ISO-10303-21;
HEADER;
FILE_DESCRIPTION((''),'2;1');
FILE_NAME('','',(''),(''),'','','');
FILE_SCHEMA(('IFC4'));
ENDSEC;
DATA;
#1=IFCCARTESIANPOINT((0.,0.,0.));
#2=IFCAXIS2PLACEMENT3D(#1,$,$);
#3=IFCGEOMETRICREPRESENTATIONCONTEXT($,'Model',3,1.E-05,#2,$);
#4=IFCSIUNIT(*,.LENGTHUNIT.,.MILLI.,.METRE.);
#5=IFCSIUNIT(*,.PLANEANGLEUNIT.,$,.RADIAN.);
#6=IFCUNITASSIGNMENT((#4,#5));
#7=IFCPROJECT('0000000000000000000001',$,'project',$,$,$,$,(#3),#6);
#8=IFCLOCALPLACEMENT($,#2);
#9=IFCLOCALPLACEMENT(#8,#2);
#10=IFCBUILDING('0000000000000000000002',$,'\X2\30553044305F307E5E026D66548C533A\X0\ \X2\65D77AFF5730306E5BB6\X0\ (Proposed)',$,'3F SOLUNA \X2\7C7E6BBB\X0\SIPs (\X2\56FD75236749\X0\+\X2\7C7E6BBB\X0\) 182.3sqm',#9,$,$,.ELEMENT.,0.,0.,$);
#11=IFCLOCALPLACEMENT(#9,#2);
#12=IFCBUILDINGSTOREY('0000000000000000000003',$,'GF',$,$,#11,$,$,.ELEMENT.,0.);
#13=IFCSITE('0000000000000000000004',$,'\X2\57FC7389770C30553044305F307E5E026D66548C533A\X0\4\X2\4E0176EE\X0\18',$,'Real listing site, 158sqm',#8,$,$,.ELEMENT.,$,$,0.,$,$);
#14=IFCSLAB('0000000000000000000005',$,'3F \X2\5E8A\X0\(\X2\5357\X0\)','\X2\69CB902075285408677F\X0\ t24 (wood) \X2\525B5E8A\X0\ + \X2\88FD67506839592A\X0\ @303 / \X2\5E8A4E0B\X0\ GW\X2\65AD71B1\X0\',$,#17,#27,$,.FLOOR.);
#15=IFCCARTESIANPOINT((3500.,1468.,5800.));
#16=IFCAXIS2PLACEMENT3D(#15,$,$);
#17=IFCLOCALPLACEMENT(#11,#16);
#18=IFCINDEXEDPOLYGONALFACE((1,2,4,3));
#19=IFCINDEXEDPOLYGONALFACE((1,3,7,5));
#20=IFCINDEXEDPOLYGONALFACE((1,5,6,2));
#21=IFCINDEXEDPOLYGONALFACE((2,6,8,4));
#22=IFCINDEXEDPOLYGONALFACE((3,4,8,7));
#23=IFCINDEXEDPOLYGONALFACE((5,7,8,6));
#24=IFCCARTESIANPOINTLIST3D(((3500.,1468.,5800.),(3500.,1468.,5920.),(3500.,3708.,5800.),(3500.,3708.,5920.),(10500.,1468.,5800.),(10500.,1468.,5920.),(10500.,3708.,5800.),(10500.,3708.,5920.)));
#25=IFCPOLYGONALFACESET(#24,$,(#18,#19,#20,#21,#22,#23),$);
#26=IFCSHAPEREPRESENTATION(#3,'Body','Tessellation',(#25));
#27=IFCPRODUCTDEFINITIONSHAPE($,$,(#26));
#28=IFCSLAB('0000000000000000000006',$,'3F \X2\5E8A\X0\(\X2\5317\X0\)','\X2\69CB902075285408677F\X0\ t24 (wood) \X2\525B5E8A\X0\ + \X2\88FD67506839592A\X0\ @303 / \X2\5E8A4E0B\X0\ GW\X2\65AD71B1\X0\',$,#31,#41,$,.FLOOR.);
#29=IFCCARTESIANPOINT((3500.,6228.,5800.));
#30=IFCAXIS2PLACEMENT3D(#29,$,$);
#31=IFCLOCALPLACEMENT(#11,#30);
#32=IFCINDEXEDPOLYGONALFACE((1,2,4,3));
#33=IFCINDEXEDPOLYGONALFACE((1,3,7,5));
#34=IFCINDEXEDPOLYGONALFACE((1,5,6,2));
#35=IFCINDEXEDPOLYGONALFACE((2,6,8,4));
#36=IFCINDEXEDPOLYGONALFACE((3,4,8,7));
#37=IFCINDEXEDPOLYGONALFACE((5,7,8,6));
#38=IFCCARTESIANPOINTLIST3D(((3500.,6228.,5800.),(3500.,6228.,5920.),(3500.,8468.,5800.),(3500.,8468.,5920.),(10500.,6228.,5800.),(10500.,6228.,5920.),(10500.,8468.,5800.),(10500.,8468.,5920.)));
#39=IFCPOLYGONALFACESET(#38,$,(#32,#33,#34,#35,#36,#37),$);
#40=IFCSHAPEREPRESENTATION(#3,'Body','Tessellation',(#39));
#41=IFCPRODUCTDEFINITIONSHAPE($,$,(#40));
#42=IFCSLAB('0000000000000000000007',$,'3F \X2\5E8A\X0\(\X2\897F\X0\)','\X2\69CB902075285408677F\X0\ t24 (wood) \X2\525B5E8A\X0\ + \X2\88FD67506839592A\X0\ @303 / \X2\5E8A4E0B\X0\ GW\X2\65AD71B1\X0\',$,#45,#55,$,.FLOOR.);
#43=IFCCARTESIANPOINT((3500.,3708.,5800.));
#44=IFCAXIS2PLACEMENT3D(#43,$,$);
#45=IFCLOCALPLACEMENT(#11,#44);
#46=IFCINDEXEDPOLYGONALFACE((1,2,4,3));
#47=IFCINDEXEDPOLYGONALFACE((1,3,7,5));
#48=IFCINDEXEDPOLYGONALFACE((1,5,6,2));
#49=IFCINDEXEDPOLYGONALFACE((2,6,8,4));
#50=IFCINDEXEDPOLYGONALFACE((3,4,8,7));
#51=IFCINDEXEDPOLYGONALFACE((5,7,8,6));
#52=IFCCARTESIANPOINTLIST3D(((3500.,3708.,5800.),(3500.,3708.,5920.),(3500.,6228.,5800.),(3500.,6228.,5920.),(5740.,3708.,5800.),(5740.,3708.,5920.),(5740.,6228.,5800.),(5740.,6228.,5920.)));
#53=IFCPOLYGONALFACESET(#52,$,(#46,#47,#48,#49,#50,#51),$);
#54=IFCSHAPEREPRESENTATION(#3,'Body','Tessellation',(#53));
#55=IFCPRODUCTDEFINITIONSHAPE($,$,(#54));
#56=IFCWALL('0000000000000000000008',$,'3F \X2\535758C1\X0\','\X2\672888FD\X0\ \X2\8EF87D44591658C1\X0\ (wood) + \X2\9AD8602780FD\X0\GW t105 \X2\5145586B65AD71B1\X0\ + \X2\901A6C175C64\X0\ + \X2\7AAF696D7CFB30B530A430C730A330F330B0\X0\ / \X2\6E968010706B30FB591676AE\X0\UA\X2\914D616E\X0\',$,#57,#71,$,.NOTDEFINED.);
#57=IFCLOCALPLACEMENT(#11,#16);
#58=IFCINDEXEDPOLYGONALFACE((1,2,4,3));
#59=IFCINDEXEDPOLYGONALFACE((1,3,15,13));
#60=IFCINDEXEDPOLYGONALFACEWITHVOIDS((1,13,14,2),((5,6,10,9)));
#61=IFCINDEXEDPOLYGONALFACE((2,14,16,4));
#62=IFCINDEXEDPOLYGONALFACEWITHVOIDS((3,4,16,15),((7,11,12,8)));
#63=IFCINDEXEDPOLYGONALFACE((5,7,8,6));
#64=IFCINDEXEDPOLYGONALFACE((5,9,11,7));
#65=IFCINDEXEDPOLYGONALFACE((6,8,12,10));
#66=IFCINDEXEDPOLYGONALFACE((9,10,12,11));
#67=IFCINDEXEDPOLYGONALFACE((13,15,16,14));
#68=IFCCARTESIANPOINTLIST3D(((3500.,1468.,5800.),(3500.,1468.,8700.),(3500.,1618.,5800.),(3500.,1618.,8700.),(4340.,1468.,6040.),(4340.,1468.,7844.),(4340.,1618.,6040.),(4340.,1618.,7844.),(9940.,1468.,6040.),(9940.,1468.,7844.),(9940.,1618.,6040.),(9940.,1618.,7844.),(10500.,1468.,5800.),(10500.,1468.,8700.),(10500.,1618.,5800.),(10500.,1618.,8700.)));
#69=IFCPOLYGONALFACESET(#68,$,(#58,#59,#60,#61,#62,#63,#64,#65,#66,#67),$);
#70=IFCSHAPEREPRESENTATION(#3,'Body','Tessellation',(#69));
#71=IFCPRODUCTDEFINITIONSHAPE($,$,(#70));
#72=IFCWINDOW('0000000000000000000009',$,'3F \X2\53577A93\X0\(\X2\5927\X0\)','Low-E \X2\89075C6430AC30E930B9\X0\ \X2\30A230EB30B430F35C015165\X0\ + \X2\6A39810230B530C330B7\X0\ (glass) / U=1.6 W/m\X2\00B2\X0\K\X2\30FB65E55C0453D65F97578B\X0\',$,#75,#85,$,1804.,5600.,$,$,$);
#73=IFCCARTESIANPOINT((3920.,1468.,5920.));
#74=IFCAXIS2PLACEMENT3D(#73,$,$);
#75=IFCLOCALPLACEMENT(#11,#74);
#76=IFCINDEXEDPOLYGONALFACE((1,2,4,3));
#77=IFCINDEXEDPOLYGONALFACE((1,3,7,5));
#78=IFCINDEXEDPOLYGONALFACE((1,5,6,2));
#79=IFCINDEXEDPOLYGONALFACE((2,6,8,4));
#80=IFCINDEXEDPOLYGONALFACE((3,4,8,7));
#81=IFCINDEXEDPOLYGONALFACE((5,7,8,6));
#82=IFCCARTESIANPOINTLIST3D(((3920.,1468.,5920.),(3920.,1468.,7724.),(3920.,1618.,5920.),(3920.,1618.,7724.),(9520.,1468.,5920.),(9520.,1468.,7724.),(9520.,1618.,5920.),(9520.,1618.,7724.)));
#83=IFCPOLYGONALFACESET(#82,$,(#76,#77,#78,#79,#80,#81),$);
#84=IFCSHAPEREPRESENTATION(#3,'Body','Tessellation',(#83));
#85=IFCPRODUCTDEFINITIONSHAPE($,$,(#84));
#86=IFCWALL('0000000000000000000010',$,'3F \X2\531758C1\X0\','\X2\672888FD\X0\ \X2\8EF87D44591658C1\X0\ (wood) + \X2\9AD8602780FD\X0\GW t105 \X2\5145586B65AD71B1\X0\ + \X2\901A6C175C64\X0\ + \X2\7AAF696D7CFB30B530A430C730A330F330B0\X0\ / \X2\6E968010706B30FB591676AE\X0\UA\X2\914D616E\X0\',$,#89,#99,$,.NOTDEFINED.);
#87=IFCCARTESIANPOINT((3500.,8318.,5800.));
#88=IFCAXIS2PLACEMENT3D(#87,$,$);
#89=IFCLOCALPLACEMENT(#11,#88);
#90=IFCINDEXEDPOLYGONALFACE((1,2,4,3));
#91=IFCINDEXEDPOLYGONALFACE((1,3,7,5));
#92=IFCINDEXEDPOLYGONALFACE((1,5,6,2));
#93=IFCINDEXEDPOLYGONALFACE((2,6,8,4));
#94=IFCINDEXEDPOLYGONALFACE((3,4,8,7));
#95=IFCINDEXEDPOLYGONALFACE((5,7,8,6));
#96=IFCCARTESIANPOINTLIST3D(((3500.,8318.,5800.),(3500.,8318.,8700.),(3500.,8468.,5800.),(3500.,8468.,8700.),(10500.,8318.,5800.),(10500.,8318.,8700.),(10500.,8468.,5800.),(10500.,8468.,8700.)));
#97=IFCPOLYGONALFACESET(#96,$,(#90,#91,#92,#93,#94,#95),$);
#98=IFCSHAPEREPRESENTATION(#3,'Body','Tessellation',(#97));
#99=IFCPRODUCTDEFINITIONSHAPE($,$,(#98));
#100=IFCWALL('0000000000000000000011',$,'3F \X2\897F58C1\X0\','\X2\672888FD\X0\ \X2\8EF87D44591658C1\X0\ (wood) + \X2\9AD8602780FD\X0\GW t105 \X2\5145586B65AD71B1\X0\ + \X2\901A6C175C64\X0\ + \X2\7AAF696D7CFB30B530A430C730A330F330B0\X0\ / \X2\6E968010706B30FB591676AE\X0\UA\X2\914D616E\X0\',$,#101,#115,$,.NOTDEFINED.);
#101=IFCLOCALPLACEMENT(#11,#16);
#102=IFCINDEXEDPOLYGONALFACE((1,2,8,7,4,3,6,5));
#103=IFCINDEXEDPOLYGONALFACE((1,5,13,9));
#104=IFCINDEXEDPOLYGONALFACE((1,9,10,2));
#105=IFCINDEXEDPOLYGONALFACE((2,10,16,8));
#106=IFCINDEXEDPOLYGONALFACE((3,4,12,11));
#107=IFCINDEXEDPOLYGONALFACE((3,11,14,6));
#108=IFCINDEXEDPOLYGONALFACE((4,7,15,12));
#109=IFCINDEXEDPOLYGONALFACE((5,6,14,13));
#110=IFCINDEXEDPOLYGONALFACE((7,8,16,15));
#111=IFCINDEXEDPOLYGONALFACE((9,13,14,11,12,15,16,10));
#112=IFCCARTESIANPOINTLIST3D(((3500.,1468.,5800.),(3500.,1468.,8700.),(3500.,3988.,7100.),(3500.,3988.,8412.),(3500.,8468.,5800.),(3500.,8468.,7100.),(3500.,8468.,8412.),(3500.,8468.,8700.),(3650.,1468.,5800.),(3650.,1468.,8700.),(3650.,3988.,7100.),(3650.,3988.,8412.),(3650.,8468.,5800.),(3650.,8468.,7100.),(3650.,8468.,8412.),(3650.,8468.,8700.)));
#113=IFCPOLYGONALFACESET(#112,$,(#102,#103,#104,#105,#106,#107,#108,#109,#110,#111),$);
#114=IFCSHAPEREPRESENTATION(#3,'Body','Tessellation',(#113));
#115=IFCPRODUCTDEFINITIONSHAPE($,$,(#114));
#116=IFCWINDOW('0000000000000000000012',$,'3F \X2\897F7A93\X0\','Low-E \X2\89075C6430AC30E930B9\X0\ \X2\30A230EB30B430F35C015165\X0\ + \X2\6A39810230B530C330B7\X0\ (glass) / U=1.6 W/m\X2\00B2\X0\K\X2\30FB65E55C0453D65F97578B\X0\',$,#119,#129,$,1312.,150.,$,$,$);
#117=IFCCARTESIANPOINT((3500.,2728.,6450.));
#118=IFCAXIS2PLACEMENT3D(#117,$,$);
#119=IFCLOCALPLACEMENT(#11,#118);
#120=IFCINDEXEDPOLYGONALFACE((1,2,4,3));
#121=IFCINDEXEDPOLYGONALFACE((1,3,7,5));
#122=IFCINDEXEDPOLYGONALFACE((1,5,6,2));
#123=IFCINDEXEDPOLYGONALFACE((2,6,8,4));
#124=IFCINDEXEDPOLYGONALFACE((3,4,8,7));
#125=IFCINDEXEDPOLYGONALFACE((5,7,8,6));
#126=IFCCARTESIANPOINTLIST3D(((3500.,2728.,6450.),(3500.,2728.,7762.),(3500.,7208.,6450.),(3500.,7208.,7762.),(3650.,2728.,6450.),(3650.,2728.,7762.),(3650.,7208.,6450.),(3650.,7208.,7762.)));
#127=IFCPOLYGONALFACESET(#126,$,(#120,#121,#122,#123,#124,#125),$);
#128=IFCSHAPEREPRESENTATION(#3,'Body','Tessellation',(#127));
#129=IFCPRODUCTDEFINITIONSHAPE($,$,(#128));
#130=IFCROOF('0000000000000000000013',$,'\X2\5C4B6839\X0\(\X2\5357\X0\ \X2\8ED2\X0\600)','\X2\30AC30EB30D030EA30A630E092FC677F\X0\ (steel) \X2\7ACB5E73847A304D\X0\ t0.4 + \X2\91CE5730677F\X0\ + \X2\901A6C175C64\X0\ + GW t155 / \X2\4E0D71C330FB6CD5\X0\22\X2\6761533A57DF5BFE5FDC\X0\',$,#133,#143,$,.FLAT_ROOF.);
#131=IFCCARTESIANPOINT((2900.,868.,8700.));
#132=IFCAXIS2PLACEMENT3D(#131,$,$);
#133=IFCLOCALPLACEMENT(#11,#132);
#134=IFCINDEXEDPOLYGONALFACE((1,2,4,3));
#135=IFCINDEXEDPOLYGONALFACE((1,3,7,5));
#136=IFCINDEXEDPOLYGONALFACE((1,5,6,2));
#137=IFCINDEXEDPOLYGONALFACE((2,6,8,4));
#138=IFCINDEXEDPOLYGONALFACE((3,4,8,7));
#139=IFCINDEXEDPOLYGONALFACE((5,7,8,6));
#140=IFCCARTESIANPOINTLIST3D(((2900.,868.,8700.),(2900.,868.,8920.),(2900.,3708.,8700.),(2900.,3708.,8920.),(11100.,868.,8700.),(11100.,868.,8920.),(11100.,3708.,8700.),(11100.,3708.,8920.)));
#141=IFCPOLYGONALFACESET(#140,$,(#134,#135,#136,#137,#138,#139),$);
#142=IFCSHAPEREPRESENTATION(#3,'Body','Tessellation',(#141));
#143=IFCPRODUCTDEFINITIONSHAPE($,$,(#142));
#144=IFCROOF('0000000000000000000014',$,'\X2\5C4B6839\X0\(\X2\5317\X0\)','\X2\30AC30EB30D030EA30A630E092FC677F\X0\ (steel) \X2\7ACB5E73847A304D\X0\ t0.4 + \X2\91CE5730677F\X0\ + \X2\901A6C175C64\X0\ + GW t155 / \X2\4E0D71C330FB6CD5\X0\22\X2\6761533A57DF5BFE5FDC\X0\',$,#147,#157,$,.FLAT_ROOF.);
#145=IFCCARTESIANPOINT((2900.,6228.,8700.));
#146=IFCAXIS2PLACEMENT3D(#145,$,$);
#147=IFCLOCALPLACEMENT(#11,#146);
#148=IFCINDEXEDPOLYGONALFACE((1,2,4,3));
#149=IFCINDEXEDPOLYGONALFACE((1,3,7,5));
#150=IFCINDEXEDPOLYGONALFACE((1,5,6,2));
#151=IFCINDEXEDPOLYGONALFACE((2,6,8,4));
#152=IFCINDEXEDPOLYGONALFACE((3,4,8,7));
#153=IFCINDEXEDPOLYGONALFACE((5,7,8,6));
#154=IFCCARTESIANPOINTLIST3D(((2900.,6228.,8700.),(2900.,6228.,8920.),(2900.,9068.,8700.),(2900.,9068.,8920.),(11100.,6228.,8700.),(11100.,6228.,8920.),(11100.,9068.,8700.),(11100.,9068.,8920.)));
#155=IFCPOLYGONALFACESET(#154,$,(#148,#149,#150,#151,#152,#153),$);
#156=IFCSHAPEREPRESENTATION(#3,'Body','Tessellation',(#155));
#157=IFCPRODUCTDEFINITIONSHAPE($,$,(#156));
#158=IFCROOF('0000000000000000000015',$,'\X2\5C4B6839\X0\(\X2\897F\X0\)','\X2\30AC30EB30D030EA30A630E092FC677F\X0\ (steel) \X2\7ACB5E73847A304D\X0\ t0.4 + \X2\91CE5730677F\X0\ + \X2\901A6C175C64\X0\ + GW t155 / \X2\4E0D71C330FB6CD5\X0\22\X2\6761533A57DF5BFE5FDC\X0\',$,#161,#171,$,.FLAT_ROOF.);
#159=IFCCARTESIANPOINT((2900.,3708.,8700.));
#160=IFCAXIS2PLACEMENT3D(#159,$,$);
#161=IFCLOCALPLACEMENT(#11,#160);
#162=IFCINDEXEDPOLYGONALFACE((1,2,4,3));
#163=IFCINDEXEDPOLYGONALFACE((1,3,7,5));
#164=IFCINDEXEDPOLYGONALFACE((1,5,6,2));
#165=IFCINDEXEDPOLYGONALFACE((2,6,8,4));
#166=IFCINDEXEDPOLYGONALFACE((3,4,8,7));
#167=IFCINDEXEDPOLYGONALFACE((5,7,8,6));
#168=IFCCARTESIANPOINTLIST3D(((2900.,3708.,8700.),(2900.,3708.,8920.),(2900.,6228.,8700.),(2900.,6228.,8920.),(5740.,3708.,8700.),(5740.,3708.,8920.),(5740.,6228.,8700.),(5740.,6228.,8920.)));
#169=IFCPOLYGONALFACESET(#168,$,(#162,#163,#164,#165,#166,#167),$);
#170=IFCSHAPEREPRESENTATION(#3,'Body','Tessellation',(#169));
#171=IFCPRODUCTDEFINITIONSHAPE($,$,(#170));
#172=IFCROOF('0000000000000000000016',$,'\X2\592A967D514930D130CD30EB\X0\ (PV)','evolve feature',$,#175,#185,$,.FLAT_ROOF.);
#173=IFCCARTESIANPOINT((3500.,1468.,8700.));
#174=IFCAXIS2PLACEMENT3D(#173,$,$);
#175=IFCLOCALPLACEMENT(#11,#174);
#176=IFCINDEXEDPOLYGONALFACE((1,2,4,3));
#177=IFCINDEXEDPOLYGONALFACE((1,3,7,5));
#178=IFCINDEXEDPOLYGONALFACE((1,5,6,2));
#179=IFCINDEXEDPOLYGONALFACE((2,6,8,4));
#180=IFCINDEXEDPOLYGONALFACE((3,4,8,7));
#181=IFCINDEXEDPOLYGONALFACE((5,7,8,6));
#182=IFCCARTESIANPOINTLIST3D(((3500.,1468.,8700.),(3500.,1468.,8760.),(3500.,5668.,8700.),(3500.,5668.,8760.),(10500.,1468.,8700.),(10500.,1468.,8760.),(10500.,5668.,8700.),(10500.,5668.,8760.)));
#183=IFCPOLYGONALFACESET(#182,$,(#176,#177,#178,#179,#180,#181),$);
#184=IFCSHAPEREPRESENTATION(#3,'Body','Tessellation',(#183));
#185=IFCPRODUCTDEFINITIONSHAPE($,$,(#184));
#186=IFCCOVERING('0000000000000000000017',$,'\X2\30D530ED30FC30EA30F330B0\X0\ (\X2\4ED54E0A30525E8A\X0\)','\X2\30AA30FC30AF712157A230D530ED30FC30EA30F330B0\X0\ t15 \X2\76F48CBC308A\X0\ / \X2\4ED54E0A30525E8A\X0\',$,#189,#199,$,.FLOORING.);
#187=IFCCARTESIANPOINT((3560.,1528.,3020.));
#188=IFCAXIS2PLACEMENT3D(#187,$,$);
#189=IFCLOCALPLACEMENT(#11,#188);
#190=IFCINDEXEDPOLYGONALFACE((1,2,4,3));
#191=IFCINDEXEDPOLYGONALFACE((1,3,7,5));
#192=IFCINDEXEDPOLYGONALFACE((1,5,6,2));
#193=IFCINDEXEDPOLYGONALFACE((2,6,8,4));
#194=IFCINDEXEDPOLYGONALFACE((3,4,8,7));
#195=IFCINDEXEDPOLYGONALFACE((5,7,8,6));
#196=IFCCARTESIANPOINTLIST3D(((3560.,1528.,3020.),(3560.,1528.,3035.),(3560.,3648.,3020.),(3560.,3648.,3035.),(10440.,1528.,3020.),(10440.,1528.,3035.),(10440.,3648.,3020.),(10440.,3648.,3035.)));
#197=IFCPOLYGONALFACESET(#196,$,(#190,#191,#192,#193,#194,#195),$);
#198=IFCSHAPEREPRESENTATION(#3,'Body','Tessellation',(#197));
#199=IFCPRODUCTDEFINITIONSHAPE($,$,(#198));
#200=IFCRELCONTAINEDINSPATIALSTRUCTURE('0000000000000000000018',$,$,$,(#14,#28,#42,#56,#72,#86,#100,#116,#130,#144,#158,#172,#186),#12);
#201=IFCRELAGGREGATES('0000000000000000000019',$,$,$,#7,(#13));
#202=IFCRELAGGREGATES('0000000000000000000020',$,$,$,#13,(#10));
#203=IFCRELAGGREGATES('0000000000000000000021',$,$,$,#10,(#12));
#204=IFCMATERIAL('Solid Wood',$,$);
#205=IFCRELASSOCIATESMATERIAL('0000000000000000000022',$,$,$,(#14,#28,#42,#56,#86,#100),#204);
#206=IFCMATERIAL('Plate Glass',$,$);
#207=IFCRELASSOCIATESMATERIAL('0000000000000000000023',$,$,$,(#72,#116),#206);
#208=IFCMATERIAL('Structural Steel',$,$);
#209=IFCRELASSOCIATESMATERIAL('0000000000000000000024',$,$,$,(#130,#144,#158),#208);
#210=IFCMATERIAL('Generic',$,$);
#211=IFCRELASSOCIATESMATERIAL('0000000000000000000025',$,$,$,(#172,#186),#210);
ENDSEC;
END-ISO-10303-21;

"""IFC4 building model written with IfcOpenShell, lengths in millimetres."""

from ifc_helpers import new_model, si_unit, frame, frame_2d, origin, place, context, project, spatial, rectangle, extrude, material, element, fill, save


model = new_model("IFC4")

# Units and contexts
model_context = context("Model", 3, precision=1e-05, world=origin())
ifc_project = project(units=[si_unit("LENGTHUNIT", "METRE", prefix="MILLI"), si_unit("PLANEANGLEUNIT", "RADIAN")], contexts=[model_context])

# Site, building, storey
site_placement = place(None, origin())
site = spatial("IfcSite", under=ifc_project, at=site_placement, Name="埼玉県さいたま市浦和区4丁目18", ObjectType="Real listing site, 158sqm", CompositionType="ELEMENT", RefElevation=0.0)
building_placement = place(site_placement, origin())
building = spatial("IfcBuilding", under=site, at=building_placement, Name="さいたま市浦和区 旗竿地の家 (Proposed)", ObjectType="3F SOLUNA 籾殻SIPs (国産杉+籾殻) 182.3sqm", CompositionType="ELEMENT", ElevationOfRefHeight=0.0, ElevationOfTerrain=0.0)
storey_placement = place(building_placement, origin())
storey = spatial("IfcBuildingStorey", under=building, at=storey_placement, Name="GF", CompositionType="ELEMENT", Elevation=0.0)

# Slabs
ifc_material_1 = material(Name="Solid Wood")
slab_1_placement = place(storey_placement, frame((3500.0, 1468.0, 5800.0)))
element("IfcSlab", 1, at=slab_1_placement, inside=storey, material=ifc_material_1, Name="3F 床(南)", Description="構造用合板 t24 (wood) 剛床 + 製材根太 @303 / 床下 GW断熱", PredefinedType="FLOOR", context=model_context, shape_type="SweptSolid", body=[
    extrude(rectangle(XDim=7000.0, YDim=2240.0, at=frame_2d((3500.0, 1120.0))), frame((3500.0, 1468.0, 5800.0)), (0.0, 0.0, 1.0), 120.0),
])
slab_2_placement = place(storey_placement, frame((3500.0, 6228.0, 5800.0)))
element("IfcSlab", 2, at=slab_2_placement, inside=storey, material=ifc_material_1, Name="3F 床(北)", Description="構造用合板 t24 (wood) 剛床 + 製材根太 @303 / 床下 GW断熱", PredefinedType="FLOOR", context=model_context, shape_type="SweptSolid", body=[
    extrude(rectangle(XDim=7000.0, YDim=2240.0, at=frame_2d((3500.0, 1120.0))), frame((3500.0, 6228.0, 5800.0)), (0.0, 0.0, 1.0), 120.0),
])
slab_3_placement = place(storey_placement, frame((3500.0, 3708.0, 5800.0)))
element("IfcSlab", 3, at=slab_3_placement, inside=storey, material=ifc_material_1, Name="3F 床(西)", Description="構造用合板 t24 (wood) 剛床 + 製材根太 @303 / 床下 GW断熱", PredefinedType="FLOOR", context=model_context, shape_type="SweptSolid", body=[
    extrude(rectangle(XDim=2240.0, YDim=2520.0, at=frame_2d((1120.0, 1260.0))), frame((3500.0, 3708.0, 5800.0)), (0.0, 0.0, 1.0), 120.0),
])

# Wall, opening, window
wall_1_placement = place(storey_placement, frame((3500.0, 1468.0, 5800.0)))
wall_1 = element("IfcWall", 4, at=wall_1_placement, inside=storey, material=ifc_material_1, Name="3F 南壁", Description="木製 軸組外壁 (wood) + 高性能GW t105 充填断熱 + 通気層 + 窯業系サイディング / 準耐火・外皮UA配慮", PredefinedType="NOTDEFINED", context=model_context, shape_type="SweptSolid", body=[
    extrude(rectangle(XDim=7000.0, YDim=150.0, at=frame_2d((3500.0, 75.0))), frame((3500.0, 1468.0, 5800.0)), (0.0, 0.0, 1.0), 2900.0),
])
opening_1_placement = place(storey_placement, frame((3920.0, 1468.0, 5920.0)))
opening_1 = element("IfcOpeningElement", 5, at=opening_1_placement, cuts=wall_1, PredefinedType="NOTDEFINED", context=model_context, shape_type="SweptSolid", body=[
    extrude(rectangle(XDim=5600.0, YDim=150.0, at=frame_2d((2800.0, 75.0))), frame((3920.0, 1468.0, 5920.0)), (0.0, 0.0, 1.0), 1804.0),
])
ifc_material_2 = material(Name="Plate Glass")
window_1_placement = place(storey_placement, frame((3920.0, 1468.0, 5920.0)))
window_1 = element("IfcWindow", 6, at=window_1_placement, inside=storey, material=ifc_material_2, Name="3F 南窓(大)", Description="Low-E 複層ガラス アルゴン封入 + 樹脂サッシ (glass) / U=1.6 W/m²K・日射取得型", OverallHeight=1804.0, OverallWidth=5600.0, context=model_context, shape_type="SweptSolid", body=[
    extrude(rectangle(XDim=5600.0, YDim=150.0, at=frame_2d((2800.0, 75.0))), frame((3920.0, 1468.0, 5920.0)), (0.0, 0.0, 1.0), 1804.0),
])
fill(opening_1, window_1)

# Wall
wall_2_placement = place(storey_placement, frame((3500.0, 8318.0, 5800.0)))
element("IfcWall", 7, at=wall_2_placement, inside=storey, material=ifc_material_1, Name="3F 北壁", Description="木製 軸組外壁 (wood) + 高性能GW t105 充填断熱 + 通気層 + 窯業系サイディング / 準耐火・外皮UA配慮", PredefinedType="NOTDEFINED", context=model_context, shape_type="SweptSolid", body=[
    extrude(rectangle(XDim=7000.0, YDim=150.0, at=frame_2d((3500.0, 75.0))), frame((3500.0, 8318.0, 5800.0)), (0.0, 0.0, 1.0), 2900.0),
])

# Wall, opening, window
wall_3_placement = place(storey_placement, frame((3500.0, 1468.0, 5800.0)))
wall_3 = element("IfcWall", 8, at=wall_3_placement, inside=storey, material=ifc_material_1, Name="3F 西壁", Description="木製 軸組外壁 (wood) + 高性能GW t105 充填断熱 + 通気層 + 窯業系サイディング / 準耐火・外皮UA配慮", PredefinedType="NOTDEFINED", context=model_context, shape_type="SweptSolid", body=[
    extrude(rectangle(XDim=150.0, YDim=7000.0, at=frame_2d((75.0, 3500.0))), frame((3500.0, 1468.0, 5800.0)), (0.0, 0.0, 1.0), 2900.0),
])
opening_2_placement = place(storey_placement, frame((3500.0, 2728.0, 6450.0)))
opening_2 = element("IfcOpeningElement", 9, at=opening_2_placement, cuts=wall_3, PredefinedType="NOTDEFINED", context=model_context, shape_type="SweptSolid", body=[
    extrude(rectangle(XDim=150.0, YDim=4480.0, at=frame_2d((75.0, 2240.0))), frame((3500.0, 2728.0, 6450.0)), (0.0, 0.0, 1.0), 1312.0),
])
window_2_placement = place(storey_placement, frame((3500.0, 2728.0, 6450.0)))
window_2 = element("IfcWindow", 10, at=window_2_placement, inside=storey, material=ifc_material_2, Name="3F 西窓", Description="Low-E 複層ガラス アルゴン封入 + 樹脂サッシ (glass) / U=1.6 W/m²K・日射取得型", OverallHeight=1312.0, OverallWidth=150.0, context=model_context, shape_type="SweptSolid", body=[
    extrude(rectangle(XDim=150.0, YDim=4480.0, at=frame_2d((75.0, 2240.0))), frame((3500.0, 2728.0, 6450.0)), (0.0, 0.0, 1.0), 1312.0),
])
fill(opening_2, window_2)

# Roofs
ifc_material_3 = material(Name="Structural Steel")
roof_1_placement = place(storey_placement, frame((2900.0, 868.0, 8700.0)))
element("IfcRoof", 11, at=roof_1_placement, inside=storey, material=ifc_material_3, Name="屋根(南 軒600)", Description="ガルバリウム鋼板 (steel) 立平葺き t0.4 + 野地板 + 通気層 + GW t155 / 不燃・法22条区域対応", PredefinedType="FLAT_ROOF", context=model_context, shape_type="SweptSolid", body=[
    extrude(rectangle(XDim=8200.0, YDim=2840.0, at=frame_2d((4100.0, 1420.0))), frame((2900.0, 868.0, 8700.0)), (0.0, 0.0, 1.0), 220.0),
])
roof_2_placement = place(storey_placement, frame((2900.0, 6228.0, 8700.0)))
element("IfcRoof", 12, at=roof_2_placement, inside=storey, material=ifc_material_3, Name="屋根(北)", Description="ガルバリウム鋼板 (steel) 立平葺き t0.4 + 野地板 + 通気層 + GW t155 / 不燃・法22条区域対応", PredefinedType="FLAT_ROOF", context=model_context, shape_type="SweptSolid", body=[
    extrude(rectangle(XDim=8200.0, YDim=2840.0, at=frame_2d((4100.0, 1420.0))), frame((2900.0, 6228.0, 8700.0)), (0.0, 0.0, 1.0), 220.0),
])
roof_3_placement = place(storey_placement, frame((2900.0, 3708.0, 8700.0)))
element("IfcRoof", 13, at=roof_3_placement, inside=storey, material=ifc_material_3, Name="屋根(西)", Description="ガルバリウム鋼板 (steel) 立平葺き t0.4 + 野地板 + 通気層 + GW t155 / 不燃・法22条区域対応", PredefinedType="FLAT_ROOF", context=model_context, shape_type="SweptSolid", body=[
    extrude(rectangle(XDim=2840.0, YDim=2520.0, at=frame_2d((1420.0, 1260.0))), frame((2900.0, 3708.0, 8700.0)), (0.0, 0.0, 1.0), 220.0),
])
ifc_material_4 = material(Name="Generic")
roof_4_placement = place(storey_placement, frame((3500.0, 1468.0, 8700.0)))
element("IfcRoof", 14, at=roof_4_placement, inside=storey, material=ifc_material_4, Name="太陽光パネル (PV)", Description="evolve feature", PredefinedType="FLAT_ROOF", context=model_context, shape_type="SweptSolid", body=[
    extrude(rectangle(XDim=7000.0, YDim=4200.0, at=frame_2d((3500.0, 2100.0))), frame((3500.0, 1468.0, 8700.0)), (0.0, 0.0, 1.0), 60.0),
])

# Covering
covering_1_placement = place(storey_placement, frame((3560.0, 1528.0, 3020.0)))
element("IfcCovering", 15, at=covering_1_placement, inside=storey, material=ifc_material_4, Name="フローリング (仕上げ床)", Description="オーク無垢フローリング t15 直貼り / 仕上げ床", PredefinedType="FLOORING", context=model_context, shape_type="SweptSolid", body=[
    extrude(rectangle(XDim=6880.0, YDim=2120.0, at=frame_2d((3440.0, 1060.0))), frame((3560.0, 1528.0, 3020.0)), (0.0, 0.0, 1.0), 15.0),
])

save(model, "model.ifc")
